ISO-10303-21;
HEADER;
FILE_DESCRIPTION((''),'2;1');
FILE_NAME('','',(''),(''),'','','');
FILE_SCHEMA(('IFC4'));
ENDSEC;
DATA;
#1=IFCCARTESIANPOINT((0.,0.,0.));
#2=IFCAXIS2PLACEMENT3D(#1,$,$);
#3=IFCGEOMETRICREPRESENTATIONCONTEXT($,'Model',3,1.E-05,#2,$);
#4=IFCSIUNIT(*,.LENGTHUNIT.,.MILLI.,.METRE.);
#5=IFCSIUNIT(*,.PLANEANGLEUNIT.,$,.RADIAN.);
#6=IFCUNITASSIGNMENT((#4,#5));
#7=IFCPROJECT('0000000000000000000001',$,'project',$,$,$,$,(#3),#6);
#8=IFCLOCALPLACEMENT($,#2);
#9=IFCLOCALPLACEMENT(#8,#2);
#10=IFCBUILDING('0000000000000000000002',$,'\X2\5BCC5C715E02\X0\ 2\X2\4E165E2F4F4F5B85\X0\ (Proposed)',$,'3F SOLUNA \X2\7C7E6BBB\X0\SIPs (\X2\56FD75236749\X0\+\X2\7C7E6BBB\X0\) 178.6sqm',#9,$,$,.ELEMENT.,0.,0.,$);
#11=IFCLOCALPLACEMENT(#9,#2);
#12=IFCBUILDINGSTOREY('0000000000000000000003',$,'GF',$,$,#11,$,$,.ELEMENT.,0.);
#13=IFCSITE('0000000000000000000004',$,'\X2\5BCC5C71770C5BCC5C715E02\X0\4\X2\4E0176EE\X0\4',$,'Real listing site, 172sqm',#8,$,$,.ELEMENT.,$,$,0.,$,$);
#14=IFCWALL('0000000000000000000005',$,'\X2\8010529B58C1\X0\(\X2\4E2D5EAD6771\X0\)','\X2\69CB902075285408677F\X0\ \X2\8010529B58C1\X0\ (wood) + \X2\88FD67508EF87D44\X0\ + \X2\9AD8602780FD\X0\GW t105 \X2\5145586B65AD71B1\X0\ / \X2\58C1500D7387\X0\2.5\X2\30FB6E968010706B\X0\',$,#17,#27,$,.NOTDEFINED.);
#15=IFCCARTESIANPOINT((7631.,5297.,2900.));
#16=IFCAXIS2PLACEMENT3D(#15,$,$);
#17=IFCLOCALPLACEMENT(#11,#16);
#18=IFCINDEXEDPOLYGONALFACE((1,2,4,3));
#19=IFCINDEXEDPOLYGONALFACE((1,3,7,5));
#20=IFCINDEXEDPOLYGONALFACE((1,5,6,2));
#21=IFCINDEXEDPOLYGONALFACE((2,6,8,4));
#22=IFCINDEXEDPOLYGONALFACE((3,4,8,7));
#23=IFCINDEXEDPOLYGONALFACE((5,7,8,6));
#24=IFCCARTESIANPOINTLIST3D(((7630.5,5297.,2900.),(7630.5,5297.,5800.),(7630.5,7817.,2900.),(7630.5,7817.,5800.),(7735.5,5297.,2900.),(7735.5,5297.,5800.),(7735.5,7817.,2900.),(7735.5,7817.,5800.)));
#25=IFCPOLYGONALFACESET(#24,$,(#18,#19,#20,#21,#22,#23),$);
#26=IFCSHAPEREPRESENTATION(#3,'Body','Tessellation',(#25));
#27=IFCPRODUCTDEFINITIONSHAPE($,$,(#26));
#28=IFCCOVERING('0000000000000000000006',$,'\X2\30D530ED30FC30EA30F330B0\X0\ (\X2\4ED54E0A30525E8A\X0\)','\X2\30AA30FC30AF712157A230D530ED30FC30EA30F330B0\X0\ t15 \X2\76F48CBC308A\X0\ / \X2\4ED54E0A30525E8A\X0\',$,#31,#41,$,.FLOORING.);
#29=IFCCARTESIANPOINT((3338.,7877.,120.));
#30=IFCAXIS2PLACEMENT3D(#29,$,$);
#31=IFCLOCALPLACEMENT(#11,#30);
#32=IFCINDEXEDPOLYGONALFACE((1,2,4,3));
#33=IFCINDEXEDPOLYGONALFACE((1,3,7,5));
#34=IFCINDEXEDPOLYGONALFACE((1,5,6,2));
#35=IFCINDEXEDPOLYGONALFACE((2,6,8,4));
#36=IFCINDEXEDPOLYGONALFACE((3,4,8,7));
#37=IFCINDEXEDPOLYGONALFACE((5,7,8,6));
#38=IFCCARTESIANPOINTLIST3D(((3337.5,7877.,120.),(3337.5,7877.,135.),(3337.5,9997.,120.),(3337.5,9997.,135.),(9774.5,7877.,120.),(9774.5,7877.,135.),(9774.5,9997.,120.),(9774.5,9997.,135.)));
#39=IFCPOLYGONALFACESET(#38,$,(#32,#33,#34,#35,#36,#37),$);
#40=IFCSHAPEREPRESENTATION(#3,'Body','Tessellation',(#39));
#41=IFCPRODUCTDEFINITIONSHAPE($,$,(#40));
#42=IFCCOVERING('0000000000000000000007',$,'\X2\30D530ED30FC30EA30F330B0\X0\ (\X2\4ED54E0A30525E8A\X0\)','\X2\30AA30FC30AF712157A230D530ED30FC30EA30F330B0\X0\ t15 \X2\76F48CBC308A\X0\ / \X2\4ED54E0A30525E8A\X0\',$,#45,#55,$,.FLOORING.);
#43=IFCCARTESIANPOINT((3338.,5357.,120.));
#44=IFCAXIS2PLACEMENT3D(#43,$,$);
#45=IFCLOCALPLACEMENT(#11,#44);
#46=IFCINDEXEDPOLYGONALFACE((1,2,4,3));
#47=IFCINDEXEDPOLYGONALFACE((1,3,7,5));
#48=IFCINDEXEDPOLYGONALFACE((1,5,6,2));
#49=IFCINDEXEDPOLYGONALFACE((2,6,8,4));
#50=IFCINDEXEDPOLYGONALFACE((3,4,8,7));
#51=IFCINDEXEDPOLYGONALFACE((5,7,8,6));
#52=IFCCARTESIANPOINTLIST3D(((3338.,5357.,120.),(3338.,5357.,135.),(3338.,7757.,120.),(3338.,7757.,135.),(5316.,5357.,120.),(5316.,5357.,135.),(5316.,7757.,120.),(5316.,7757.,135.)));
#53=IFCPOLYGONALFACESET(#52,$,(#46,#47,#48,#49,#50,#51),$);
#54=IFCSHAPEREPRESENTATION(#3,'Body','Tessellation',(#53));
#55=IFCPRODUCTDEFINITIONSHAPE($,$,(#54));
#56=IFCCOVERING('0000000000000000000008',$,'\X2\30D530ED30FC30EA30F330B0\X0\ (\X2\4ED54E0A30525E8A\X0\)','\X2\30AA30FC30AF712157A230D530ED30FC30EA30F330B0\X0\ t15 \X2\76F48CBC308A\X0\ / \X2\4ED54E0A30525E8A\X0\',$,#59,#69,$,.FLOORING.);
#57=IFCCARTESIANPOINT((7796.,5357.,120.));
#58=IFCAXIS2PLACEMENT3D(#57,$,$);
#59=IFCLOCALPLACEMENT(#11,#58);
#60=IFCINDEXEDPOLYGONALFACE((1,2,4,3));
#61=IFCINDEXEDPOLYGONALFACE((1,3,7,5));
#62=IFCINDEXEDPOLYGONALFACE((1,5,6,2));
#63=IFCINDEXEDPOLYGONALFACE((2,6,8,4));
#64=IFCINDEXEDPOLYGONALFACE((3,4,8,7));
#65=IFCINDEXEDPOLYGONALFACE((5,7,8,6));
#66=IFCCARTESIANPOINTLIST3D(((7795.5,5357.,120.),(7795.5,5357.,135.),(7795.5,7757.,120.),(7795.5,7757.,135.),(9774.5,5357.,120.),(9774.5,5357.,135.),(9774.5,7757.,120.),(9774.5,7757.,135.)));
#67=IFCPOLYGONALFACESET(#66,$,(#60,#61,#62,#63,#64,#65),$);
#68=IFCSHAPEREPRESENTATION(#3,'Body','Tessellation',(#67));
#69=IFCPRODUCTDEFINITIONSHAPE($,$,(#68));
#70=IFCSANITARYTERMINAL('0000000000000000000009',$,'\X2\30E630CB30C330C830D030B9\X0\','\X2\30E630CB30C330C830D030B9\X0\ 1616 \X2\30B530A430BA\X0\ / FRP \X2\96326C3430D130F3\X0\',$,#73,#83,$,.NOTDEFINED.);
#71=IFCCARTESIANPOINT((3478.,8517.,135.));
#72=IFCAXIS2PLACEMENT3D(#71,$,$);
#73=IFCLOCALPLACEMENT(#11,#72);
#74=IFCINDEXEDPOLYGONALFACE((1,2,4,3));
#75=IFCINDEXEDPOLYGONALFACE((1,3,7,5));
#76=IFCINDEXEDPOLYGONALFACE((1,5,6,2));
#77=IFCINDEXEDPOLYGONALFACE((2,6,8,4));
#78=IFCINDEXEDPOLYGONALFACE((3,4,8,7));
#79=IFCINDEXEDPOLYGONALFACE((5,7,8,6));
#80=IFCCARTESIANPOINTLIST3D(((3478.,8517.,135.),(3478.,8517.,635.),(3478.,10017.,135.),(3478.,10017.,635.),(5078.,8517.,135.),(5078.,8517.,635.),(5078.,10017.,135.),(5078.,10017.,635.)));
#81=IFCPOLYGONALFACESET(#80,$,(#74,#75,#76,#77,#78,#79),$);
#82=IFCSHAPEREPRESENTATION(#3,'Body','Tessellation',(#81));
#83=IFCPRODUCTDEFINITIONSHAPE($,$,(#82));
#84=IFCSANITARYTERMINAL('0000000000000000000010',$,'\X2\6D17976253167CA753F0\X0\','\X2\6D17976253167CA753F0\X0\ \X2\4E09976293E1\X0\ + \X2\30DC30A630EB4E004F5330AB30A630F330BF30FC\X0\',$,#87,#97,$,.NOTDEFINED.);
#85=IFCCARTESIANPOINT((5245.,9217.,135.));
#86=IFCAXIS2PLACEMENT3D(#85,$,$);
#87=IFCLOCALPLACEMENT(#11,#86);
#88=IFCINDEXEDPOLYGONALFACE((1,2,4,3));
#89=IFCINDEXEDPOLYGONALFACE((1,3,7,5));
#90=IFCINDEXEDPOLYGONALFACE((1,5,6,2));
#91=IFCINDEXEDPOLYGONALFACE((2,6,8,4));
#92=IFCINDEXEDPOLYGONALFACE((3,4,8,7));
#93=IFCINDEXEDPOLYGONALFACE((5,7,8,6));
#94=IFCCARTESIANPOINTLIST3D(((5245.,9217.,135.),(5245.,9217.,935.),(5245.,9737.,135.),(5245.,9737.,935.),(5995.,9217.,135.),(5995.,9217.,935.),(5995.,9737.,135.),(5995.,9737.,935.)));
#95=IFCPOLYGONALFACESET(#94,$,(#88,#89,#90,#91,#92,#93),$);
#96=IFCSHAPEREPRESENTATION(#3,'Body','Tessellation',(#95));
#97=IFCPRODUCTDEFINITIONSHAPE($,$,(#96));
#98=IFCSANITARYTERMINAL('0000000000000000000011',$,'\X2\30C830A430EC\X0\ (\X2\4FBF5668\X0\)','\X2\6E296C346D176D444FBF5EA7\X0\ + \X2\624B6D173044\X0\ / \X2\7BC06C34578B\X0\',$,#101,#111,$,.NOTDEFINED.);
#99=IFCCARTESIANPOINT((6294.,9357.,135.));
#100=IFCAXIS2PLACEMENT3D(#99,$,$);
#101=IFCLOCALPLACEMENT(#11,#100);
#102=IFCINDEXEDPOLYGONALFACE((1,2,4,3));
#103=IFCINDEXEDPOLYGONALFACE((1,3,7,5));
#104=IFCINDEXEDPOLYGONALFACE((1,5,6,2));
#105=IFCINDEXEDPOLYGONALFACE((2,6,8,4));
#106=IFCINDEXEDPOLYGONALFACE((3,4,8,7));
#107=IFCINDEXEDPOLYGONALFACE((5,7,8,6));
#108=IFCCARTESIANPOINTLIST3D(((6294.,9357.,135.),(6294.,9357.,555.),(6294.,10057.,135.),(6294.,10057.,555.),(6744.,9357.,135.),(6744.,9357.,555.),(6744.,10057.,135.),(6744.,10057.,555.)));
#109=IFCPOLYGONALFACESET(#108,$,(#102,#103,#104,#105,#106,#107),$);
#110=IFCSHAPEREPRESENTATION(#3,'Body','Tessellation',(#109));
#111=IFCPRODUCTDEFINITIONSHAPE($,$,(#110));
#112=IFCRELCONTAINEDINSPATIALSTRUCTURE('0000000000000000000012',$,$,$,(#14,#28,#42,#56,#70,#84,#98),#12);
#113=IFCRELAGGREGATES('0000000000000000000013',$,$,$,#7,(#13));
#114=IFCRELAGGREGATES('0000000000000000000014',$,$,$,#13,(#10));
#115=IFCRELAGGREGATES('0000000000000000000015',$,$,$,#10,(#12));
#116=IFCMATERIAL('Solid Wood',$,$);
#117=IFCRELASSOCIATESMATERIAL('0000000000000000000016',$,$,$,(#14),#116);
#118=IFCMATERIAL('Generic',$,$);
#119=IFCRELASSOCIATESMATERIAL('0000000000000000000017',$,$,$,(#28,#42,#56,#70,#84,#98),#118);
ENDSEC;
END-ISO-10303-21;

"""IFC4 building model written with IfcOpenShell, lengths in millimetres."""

from ifc_helpers import new_model, si_unit, frame, frame_2d, origin, place, context, project, spatial, rectangle, extrude, material, element, save


model = new_model("IFC4")

# Units and contexts
model_context = context("Model", 3, precision=1e-05, world=origin())
ifc_project = project(units=[si_unit("LENGTHUNIT", "METRE", prefix="MILLI"), si_unit("PLANEANGLEUNIT", "RADIAN")], contexts=[model_context])

# Site, building, storey
site_placement = place(None, origin())
site = spatial("IfcSite", under=ifc_project, at=site_placement, Name="富山県富山市4丁目4", ObjectType="Real listing site, 172sqm", CompositionType="ELEMENT", RefElevation=0.0)
building_placement = place(site_placement, origin())
building = spatial("IfcBuilding", under=site, at=building_placement, Name="富山市 2世帯住宅 (Proposed)", ObjectType="3F SOLUNA 籾殻SIPs (国産杉+籾殻) 178.6sqm", CompositionType="ELEMENT", ElevationOfRefHeight=0.0, ElevationOfTerrain=0.0)
storey_placement = place(building_placement, origin())
storey = spatial("IfcBuildingStorey", under=building, at=storey_placement, Name="GF", CompositionType="ELEMENT", Elevation=0.0)

# Shared definitions
ifc_material_1 = material(Name="Solid Wood")

# Wall
wall_1_placement = place(storey_placement, frame((7631.0, 5297.0, 2900.0)))
element("IfcWall", 1, at=wall_1_placement, inside=storey, material=ifc_material_1, Name="耐力壁(中庭東)", Description="構造用合板 耐力壁 (wood) + 製材軸組 + 高性能GW t105 充填断熱 / 壁倍率2.5・準耐火", PredefinedType="NOTDEFINED", context=model_context, shape_type="SweptSolid", body=[
    extrude(rectangle(XDim=105.0, YDim=2520.0, at=frame_2d((52.0, 1260.0))), frame((7631.0, 5297.0, 2900.0)), (0.0, 0.0, 1.0), 2900.0),
])

# Coverings
ifc_material_2 = material(Name="Generic")
covering_1_placement = place(storey_placement, frame((3338.0, 7877.0, 120.0)))
element("IfcCovering", 2, at=covering_1_placement, inside=storey, material=ifc_material_2, Name="フローリング (仕上げ床)", Description="オーク無垢フローリング t15 直貼り / 仕上げ床", PredefinedType="FLOORING", context=model_context, shape_type="SweptSolid", body=[
    extrude(rectangle(XDim=6437.0, YDim=2120.0, at=frame_2d((3218.0, 1060.0))), frame((3338.0, 7877.0, 120.0)), (0.0, 0.0, 1.0), 15.0),
])
covering_2_placement = place(storey_placement, frame((3338.0, 5357.0, 120.0)))
element("IfcCovering", 3, at=covering_2_placement, inside=storey, material=ifc_material_2, Name="フローリング (仕上げ床)", Description="オーク無垢フローリング t15 直貼り / 仕上げ床", PredefinedType="FLOORING", context=model_context, shape_type="SweptSolid", body=[
    extrude(rectangle(XDim=1978.0, YDim=2400.0, at=frame_2d((989.0, 1200.0))), frame((3338.0, 5357.0, 120.0)), (0.0, 0.0, 1.0), 15.0),
])
covering_3_placement = place(storey_placement, frame((7796.0, 5357.0, 120.0)))
element("IfcCovering", 4, at=covering_3_placement, inside=storey, material=ifc_material_2, Name="フローリング (仕上げ床)", Description="オーク無垢フローリング t15 直貼り / 仕上げ床", PredefinedType="FLOORING", context=model_context, shape_type="SweptSolid", body=[
    extrude(rectangle(XDim=1979.0, YDim=2400.0, at=frame_2d((989.0, 1200.0))), frame((7796.0, 5357.0, 120.0)), (0.0, 0.0, 1.0), 15.0),
])

# Sanitary terminals
sanitary_terminal_1_placement = place(storey_placement, frame((3478.0, 8517.0, 135.0)))
element("IfcSanitaryTerminal", 5, at=sanitary_terminal_1_placement, inside=storey, material=ifc_material_2, Name="ユニットバス", Description="ユニットバス 1616 サイズ / FRP 防水パン", PredefinedType="NOTDEFINED", context=model_context, shape_type="SweptSolid", body=[
    extrude(rectangle(XDim=1600.0, YDim=1500.0, at=frame_2d((800.0, 750.0))), frame((3478.0, 8517.0, 135.0)), (0.0, 0.0, 1.0), 500.0),
])
sanitary_terminal_2_placement = place(storey_placement, frame((5245.0, 9217.0, 135.0)))
element("IfcSanitaryTerminal", 6, at=sanitary_terminal_2_placement, inside=storey, material=ifc_material_2, Name="洗面化粧台", Description="洗面化粧台 三面鏡 + ボウル一体カウンター", PredefinedType="NOTDEFINED", context=model_context, shape_type="SweptSolid", body=[
    extrude(rectangle(XDim=750.0, YDim=520.0, at=frame_2d((375.0, 260.0))), frame((5245.0, 9217.0, 135.0)), (0.0, 0.0, 1.0), 800.0),
])
sanitary_terminal_3_placement = place(storey_placement, frame((6294.0, 9357.0, 135.0)))
element("IfcSanitaryTerminal", 7, at=sanitary_terminal_3_placement, inside=storey, material=ifc_material_2, Name="トイレ (便器)", Description="温水洗浄便座 + 手洗い / 節水型", PredefinedType="NOTDEFINED", context=model_context, shape_type="SweptSolid", body=[
    extrude(rectangle(XDim=450.0, YDim=700.0, at=frame_2d((225.0, 350.0))), frame((6294.0, 9357.0, 135.0)), (0.0, 0.0, 1.0), 420.0),
])

save(model, "model.ifc")
